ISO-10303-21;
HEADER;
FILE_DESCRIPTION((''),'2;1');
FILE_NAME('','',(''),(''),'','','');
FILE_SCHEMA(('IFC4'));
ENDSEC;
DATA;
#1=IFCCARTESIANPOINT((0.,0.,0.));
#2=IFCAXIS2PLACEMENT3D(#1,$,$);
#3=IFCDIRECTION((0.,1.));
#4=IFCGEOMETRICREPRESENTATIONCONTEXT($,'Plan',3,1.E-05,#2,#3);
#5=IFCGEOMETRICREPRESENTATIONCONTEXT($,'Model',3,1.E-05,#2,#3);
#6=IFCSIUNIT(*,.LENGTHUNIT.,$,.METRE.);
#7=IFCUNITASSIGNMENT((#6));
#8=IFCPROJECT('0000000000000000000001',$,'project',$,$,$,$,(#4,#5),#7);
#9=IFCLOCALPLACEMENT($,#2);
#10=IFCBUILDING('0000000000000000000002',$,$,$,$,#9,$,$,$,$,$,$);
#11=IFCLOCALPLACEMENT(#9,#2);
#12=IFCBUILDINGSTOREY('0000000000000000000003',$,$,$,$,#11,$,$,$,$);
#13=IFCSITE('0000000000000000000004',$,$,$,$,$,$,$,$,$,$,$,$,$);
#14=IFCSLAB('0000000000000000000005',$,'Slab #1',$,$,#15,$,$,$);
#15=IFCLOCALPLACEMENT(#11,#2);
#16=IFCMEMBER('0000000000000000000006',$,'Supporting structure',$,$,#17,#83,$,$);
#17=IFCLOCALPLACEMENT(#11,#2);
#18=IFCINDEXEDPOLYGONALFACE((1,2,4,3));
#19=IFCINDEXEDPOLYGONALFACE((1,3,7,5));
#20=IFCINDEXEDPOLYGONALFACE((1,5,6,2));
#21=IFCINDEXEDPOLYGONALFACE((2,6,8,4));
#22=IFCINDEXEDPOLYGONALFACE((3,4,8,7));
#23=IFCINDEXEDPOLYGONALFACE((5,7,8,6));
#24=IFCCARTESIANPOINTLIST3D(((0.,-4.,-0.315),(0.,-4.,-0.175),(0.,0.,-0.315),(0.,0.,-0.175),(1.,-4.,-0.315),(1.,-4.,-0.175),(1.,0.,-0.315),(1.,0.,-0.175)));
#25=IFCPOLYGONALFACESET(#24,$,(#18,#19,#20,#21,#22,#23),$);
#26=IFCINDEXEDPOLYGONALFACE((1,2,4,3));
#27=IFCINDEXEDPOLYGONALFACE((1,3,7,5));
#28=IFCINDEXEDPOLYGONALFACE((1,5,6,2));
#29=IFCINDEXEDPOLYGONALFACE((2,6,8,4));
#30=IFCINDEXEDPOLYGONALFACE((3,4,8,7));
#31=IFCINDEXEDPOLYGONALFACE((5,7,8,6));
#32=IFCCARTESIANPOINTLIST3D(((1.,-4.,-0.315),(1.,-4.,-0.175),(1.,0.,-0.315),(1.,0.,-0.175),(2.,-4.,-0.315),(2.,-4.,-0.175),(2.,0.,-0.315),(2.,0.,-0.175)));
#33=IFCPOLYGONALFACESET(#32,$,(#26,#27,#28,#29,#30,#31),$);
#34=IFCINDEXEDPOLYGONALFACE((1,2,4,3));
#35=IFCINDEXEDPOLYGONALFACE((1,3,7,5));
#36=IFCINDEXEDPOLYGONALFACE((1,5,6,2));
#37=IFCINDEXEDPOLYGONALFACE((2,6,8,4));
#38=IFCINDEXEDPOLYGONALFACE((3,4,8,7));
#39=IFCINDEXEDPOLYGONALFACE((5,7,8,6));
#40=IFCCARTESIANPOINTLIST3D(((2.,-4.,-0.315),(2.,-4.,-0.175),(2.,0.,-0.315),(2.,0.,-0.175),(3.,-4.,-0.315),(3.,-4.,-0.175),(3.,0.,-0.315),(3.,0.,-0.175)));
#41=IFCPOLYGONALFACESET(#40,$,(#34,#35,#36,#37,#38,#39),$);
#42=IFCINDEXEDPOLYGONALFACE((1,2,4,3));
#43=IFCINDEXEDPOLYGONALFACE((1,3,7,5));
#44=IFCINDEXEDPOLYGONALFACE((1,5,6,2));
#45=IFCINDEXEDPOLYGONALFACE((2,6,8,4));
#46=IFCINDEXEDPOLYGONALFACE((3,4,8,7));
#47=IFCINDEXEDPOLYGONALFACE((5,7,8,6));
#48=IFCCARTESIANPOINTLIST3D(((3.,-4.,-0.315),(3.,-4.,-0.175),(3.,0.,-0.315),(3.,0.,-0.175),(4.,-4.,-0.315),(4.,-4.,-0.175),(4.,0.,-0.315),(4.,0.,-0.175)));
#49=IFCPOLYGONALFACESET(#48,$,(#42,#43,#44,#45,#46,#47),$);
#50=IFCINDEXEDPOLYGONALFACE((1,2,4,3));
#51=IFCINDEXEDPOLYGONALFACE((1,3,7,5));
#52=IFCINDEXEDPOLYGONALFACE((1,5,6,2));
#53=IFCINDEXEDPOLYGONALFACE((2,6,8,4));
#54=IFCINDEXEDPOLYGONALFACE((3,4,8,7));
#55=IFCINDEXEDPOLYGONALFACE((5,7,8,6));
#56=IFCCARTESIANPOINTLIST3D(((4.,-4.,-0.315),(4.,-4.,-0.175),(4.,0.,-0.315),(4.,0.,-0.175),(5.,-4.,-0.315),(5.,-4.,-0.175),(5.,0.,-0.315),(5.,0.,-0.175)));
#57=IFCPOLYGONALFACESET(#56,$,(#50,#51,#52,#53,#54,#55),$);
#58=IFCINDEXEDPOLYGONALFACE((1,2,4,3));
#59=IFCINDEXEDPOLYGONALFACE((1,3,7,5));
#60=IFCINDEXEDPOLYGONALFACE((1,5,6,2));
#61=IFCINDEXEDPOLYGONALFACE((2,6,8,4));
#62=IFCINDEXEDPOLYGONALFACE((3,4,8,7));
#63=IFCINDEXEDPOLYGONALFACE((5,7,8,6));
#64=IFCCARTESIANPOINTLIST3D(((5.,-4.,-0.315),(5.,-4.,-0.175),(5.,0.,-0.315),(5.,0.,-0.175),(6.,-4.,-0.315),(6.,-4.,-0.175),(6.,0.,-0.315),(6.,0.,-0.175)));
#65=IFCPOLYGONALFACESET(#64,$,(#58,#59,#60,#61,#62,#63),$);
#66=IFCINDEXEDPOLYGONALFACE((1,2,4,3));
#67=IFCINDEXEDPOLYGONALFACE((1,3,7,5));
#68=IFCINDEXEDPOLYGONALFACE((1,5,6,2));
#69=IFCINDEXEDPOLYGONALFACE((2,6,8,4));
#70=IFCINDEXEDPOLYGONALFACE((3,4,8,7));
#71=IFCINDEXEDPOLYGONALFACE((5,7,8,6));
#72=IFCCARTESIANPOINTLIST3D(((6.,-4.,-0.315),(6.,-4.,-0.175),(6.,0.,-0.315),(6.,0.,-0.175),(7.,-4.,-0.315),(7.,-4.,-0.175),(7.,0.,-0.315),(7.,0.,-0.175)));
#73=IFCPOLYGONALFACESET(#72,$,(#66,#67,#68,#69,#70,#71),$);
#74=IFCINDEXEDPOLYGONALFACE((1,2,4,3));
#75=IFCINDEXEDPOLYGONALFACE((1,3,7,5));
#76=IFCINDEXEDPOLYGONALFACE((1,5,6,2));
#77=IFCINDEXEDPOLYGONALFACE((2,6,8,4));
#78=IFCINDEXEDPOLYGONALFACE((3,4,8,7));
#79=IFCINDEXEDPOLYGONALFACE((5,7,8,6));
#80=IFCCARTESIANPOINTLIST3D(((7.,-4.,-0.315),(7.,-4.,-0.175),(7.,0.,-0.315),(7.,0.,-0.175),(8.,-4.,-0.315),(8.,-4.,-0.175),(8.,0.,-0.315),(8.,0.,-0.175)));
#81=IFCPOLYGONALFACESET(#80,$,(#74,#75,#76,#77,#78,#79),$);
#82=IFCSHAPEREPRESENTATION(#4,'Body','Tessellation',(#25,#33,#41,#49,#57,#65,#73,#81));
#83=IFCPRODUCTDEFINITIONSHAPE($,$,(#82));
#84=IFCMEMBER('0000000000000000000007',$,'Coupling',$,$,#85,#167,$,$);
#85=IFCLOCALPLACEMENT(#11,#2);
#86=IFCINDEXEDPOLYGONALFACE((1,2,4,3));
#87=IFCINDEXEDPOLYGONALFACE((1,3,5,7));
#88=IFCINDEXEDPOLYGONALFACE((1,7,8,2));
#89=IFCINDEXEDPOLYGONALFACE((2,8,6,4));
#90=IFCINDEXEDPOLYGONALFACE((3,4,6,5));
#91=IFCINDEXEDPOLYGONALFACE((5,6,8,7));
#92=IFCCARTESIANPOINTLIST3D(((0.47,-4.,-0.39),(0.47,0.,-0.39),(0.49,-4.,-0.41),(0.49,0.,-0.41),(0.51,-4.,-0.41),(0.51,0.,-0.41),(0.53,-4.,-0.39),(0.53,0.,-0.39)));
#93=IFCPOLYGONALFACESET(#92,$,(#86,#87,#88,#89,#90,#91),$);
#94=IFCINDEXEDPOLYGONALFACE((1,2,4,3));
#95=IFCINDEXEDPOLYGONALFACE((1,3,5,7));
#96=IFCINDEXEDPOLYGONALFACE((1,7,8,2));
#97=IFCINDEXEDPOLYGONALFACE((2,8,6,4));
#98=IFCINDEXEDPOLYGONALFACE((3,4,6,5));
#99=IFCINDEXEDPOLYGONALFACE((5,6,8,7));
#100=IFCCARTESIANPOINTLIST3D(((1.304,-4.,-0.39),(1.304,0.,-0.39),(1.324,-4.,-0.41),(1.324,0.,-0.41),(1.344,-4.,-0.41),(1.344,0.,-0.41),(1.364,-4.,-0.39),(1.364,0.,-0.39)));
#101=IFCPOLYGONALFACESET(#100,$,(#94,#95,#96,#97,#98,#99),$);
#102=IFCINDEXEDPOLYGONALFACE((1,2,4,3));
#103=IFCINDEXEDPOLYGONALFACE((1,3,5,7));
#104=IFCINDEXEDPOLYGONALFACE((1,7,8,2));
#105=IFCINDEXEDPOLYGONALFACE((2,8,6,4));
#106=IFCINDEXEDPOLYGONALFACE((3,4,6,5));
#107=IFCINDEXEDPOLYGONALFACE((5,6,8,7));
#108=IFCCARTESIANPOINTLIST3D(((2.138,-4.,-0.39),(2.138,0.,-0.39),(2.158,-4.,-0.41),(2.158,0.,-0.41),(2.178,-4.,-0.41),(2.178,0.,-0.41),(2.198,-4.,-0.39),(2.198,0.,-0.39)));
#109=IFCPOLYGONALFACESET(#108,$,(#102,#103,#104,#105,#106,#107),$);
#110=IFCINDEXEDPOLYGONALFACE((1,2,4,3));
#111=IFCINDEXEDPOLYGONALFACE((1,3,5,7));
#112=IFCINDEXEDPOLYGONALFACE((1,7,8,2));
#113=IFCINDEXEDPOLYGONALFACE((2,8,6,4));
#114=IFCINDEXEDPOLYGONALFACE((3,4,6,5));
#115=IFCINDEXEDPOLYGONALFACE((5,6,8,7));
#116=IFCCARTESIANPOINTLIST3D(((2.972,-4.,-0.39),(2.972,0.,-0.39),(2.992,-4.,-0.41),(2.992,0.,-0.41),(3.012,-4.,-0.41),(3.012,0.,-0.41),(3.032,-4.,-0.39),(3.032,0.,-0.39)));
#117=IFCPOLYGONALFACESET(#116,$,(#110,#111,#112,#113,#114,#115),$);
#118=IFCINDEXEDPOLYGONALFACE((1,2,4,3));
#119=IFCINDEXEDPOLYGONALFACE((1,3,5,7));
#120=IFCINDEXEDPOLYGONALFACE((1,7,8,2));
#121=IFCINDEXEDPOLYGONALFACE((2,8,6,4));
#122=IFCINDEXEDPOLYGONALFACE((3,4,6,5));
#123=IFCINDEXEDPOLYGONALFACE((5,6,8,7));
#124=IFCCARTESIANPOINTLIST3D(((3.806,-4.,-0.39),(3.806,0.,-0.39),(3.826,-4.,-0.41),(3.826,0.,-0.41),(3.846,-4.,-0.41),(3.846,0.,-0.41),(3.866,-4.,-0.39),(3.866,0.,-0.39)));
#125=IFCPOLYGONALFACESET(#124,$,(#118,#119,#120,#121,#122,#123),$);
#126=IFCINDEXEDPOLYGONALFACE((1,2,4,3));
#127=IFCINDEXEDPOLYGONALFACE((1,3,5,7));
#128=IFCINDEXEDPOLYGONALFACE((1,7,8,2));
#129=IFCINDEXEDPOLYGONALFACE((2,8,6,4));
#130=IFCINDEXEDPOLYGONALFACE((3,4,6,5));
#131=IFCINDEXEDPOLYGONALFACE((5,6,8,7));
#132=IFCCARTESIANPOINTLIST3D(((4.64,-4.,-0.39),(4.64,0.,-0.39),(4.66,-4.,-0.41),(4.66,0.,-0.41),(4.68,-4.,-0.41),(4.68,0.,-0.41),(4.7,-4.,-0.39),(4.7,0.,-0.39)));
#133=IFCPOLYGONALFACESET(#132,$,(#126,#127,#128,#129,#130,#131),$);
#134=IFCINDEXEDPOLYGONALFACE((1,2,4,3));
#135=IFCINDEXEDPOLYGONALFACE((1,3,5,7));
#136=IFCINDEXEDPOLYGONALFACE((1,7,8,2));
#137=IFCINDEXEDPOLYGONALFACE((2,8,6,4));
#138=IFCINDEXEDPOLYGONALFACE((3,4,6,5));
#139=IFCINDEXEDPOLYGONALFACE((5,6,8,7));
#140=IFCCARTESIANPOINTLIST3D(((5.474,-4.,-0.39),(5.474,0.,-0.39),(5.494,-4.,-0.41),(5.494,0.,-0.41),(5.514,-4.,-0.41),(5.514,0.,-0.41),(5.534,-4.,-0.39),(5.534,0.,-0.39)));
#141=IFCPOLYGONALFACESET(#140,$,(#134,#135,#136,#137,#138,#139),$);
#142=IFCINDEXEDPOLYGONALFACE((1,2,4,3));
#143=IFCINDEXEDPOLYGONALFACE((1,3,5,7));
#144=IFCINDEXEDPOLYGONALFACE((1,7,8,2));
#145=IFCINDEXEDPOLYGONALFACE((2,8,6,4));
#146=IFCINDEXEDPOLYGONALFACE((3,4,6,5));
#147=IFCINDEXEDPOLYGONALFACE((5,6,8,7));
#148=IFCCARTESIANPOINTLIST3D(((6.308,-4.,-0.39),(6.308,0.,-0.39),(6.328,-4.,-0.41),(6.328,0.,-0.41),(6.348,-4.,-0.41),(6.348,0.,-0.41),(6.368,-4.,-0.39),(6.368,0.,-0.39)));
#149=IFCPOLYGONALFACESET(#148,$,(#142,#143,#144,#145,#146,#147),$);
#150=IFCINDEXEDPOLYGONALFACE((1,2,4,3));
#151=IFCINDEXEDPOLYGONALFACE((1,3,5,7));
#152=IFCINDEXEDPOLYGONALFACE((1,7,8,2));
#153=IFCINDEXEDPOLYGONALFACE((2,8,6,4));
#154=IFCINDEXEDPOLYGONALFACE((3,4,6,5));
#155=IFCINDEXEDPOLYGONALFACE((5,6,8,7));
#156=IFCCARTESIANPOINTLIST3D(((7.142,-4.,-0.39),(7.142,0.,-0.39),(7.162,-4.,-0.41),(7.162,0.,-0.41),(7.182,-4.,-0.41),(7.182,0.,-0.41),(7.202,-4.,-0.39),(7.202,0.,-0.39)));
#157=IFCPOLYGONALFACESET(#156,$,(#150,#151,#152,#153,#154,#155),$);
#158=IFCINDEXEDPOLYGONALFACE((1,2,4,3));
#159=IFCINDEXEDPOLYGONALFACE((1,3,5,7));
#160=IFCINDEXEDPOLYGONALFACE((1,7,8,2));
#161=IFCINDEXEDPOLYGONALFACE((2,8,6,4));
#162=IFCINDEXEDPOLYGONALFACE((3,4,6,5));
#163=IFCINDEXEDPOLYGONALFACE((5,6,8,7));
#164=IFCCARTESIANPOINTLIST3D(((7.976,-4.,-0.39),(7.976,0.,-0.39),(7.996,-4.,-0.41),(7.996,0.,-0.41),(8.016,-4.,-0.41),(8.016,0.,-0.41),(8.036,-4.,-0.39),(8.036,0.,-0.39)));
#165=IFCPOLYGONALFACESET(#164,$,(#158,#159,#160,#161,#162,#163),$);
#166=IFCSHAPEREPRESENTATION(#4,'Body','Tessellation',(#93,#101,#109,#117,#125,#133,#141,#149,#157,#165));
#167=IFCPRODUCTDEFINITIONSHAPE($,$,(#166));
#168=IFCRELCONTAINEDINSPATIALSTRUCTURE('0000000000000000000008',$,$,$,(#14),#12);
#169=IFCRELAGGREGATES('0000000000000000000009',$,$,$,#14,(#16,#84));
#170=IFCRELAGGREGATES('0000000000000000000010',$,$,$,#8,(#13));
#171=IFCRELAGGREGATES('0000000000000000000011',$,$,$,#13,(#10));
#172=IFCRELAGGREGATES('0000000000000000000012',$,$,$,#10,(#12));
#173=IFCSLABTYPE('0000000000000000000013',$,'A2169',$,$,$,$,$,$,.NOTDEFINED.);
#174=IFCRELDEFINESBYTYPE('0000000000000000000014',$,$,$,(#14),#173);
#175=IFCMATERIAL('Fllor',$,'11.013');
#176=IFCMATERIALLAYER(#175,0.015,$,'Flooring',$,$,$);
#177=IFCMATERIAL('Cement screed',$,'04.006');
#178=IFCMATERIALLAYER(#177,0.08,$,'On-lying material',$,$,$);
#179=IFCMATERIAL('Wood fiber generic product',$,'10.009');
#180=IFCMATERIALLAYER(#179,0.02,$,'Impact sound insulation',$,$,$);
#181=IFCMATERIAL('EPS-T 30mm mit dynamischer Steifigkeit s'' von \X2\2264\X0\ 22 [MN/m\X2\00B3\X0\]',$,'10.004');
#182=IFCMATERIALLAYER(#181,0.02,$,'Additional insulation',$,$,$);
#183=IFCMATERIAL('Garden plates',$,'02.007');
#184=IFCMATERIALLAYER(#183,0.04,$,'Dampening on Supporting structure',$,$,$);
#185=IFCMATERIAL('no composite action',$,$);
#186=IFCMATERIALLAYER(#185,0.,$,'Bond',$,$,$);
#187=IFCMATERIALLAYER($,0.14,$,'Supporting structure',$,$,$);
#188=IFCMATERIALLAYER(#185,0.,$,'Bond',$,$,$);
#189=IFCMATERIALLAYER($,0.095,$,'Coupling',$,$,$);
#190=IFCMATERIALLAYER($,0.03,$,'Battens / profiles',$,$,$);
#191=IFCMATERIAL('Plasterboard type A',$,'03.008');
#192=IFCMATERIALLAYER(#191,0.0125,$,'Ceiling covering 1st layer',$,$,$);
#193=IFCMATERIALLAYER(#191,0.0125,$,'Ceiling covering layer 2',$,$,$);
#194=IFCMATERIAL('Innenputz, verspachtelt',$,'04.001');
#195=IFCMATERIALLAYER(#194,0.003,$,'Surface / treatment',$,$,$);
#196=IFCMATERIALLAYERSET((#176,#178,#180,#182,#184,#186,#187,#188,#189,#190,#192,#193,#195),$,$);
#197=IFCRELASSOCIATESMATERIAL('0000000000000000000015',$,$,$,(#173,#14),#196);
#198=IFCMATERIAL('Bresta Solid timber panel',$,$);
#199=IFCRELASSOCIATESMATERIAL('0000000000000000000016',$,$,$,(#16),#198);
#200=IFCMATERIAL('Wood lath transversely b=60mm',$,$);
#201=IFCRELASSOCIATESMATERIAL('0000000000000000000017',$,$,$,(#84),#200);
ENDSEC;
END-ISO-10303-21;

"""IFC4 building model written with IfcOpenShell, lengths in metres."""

from ifc_helpers import new_model, si_unit, direction, frame, frame_2d, origin, place, context, project, spatial, polyline, rectangle, outline, extrude, material, layer, layer_set, type_object, element, aggregate, save


model = new_model("IFC4")

# Units and contexts
plan_context = context("Plan", 3, precision=1e-05, world=origin(), true_north=direction((0.0, 1.0)))
model_context = context("Model", 3, precision=1e-05, world=origin(), true_north=direction((0.0, 1.0)))
ifc_project = project(units=[si_unit("LENGTHUNIT", "METRE")], contexts=[plan_context, model_context])

# Site, building, storey
site = spatial("IfcSite", under=ifc_project)
building_placement = place(None, origin())
building = spatial("IfcBuilding", under=site, at=building_placement)
storey_placement = place(building_placement, origin())
storey = spatial("IfcBuildingStorey", under=building, at=storey_placement)

# Slab, members
ifc_material_1 = material(Name="Fllor", Category="11.013")
ifc_layer_1 = layer(ifc_material_1, 0.015, Name="Flooring")
ifc_material_2 = material(Name="Cement screed", Category="04.006")
ifc_layer_2 = layer(ifc_material_2, 0.08, Name="On-lying material")
ifc_material_3 = material(Name="Wood fiber generic product", Category="10.009")
ifc_layer_3 = layer(ifc_material_3, 0.02, Name="Impact sound insulation")
ifc_material_4 = material(Name="EPS-T 30mm mit dynamischer Steifigkeit s' von ≤ 22 [MN/m³]", Category="10.004")
ifc_layer_4 = layer(ifc_material_4, 0.02, Name="Additional insulation")
ifc_material_5 = material(Name="Garden plates", Category="02.007")
ifc_layer_5 = layer(ifc_material_5, 0.04, Name="Dampening on Supporting structure")
ifc_material_6 = material(Name="no composite action")
ifc_layer_6 = layer(ifc_material_6, 0.0, Name="Bond")
ifc_layer_7 = layer(None, 0.14, Name="Supporting structure")
ifc_layer_8 = layer(ifc_material_6, 0.0, Name="Bond")
ifc_layer_9 = layer(None, 0.095, Name="Coupling")
ifc_layer_10 = layer(None, 0.03, Name="Battens / profiles")
ifc_material_7 = material(Name="Plasterboard type A", Category="03.008")
ifc_layer_11 = layer(ifc_material_7, 0.0125, Name="Ceiling covering 1st layer")
ifc_layer_12 = layer(ifc_material_7, 0.0125, Name="Ceiling covering layer 2")
ifc_material_8 = material(Name="Innenputz, verspachtelt", Category="04.001")
ifc_layer_13 = layer(ifc_material_8, 0.003, Name="Surface / treatment")
ifc_layer_set = layer_set([ifc_layer_1, ifc_layer_2, ifc_layer_3, ifc_layer_4, ifc_layer_5, ifc_layer_6, ifc_layer_7, ifc_layer_8, ifc_layer_9, ifc_layer_10, ifc_layer_11, ifc_layer_12, ifc_layer_13])
slab_type = type_object("IfcSlabType", Name="A2169", PredefinedType="NOTDEFINED", material=ifc_layer_set)
slab_placement = place(None, frame((0.0, 0.0, 0.0), z_axis=(0.0, 0.0, -1.0), x_axis=(1.0, 0.0, 0.0)))
slab = element("IfcSlab", 1, at=slab_placement, inside=storey, type_object=slab_type, material=ifc_layer_set, Name="Slab #1")
ifc_material_9 = material(Name="Bresta Solid timber panel")
member_1_placement = place(slab_placement, origin())
member_1 = element("IfcMember", 2, at=member_1_placement, material=ifc_material_9, Name="Supporting structure", context=plan_context, shape_type="SweptSolid", body=[
    extrude(rectangle(XDim=1.0, YDim=0.14, at=frame_2d((0.5, 0.07), x_axis=(1.0, 0.0))), frame((0.0, 4.0, 0.175), z_axis=(0.0, -1.0, 0.0), x_axis=(1.0, 0.0, 0.0)), (0.0, 0.0, 1.0), 4.0),
    extrude(rectangle(XDim=1.0, YDim=0.14, at=frame_2d((0.5, 0.07), x_axis=(1.0, 0.0))), frame((1.0, 4.0, 0.175), z_axis=(0.0, -1.0, 0.0), x_axis=(1.0, 0.0, 0.0)), (0.0, 0.0, 1.0), 4.0),
    extrude(rectangle(XDim=1.0, YDim=0.14, at=frame_2d((0.5, 0.07), x_axis=(1.0, 0.0))), frame((2.0, 4.0, 0.175), z_axis=(0.0, -1.0, 0.0), x_axis=(1.0, 0.0, 0.0)), (0.0, 0.0, 1.0), 4.0),
    extrude(rectangle(XDim=1.0, YDim=0.14, at=frame_2d((0.5, 0.07), x_axis=(1.0, 0.0))), frame((3.0, 4.0, 0.175), z_axis=(0.0, -1.0, 0.0), x_axis=(1.0, 0.0, 0.0)), (0.0, 0.0, 1.0), 4.0),
    extrude(rectangle(XDim=1.0, YDim=0.14, at=frame_2d((0.5, 0.07), x_axis=(1.0, 0.0))), frame((4.0, 4.0, 0.175), z_axis=(0.0, -1.0, 0.0), x_axis=(1.0, 0.0, 0.0)), (0.0, 0.0, 1.0), 4.0),
    extrude(rectangle(XDim=1.0, YDim=0.14, at=frame_2d((0.5, 0.07), x_axis=(1.0, 0.0))), frame((5.0, 4.0, 0.175), z_axis=(0.0, -1.0, 0.0), x_axis=(1.0, 0.0, 0.0)), (0.0, 0.0, 1.0), 4.0),
    extrude(rectangle(XDim=1.0, YDim=0.14, at=frame_2d((0.5, 0.07), x_axis=(1.0, 0.0))), frame((6.0, 4.0, 0.175), z_axis=(0.0, -1.0, 0.0), x_axis=(1.0, 0.0, 0.0)), (0.0, 0.0, 1.0), 4.0),
    extrude(rectangle(XDim=1.0, YDim=0.14, at=frame_2d((0.5, 0.07), x_axis=(1.0, 0.0))), frame((7.0, 4.0, 0.175), z_axis=(0.0, -1.0, 0.0), x_axis=(1.0, 0.0, 0.0)), (0.0, 0.0, 1.0), 4.0),
])
ifc_material_10 = material(Name="Wood lath transversely b=60mm")
member_2_placement = place(slab_placement, origin())
member_2 = element("IfcMember", 3, at=member_2_placement, material=ifc_material_10, Name="Coupling", context=plan_context, shape_type="SweptSolid", body=[
    extrude(outline(polyline([(0.0, 0.0), (0.06, 0.0), (0.04, 0.02), (0.02, 0.02), (0.0, 0.0)])), frame((0.47, 4.0, 0.39), z_axis=(0.0, -1.0, 0.0), x_axis=(1.0, 0.0, 0.0)), (0.0, 0.0, 1.0), 4.0),
    extrude(outline(polyline([(0.0, 0.0), (0.06, 0.0), (0.04, 0.02), (0.02, 0.02), (0.0, 0.0)])), frame((1.304, 4.0, 0.39), z_axis=(0.0, -1.0, 0.0), x_axis=(1.0, 0.0, 0.0)), (0.0, 0.0, 1.0), 4.0),
    extrude(outline(polyline([(0.0, 0.0), (0.06, 0.0), (0.04, 0.02), (0.02, 0.02), (0.0, 0.0)])), frame((2.138, 4.0, 0.39), z_axis=(0.0, -1.0, 0.0), x_axis=(1.0, 0.0, 0.0)), (0.0, 0.0, 1.0), 4.0),
    extrude(outline(polyline([(0.0, 0.0), (0.06, 0.0), (0.04, 0.02), (0.02, 0.02), (0.0, 0.0)])), frame((2.972, 4.0, 0.39), z_axis=(0.0, -1.0, 0.0), x_axis=(1.0, 0.0, 0.0)), (0.0, 0.0, 1.0), 4.0),
    extrude(outline(polyline([(0.0, 0.0), (0.06, 0.0), (0.04, 0.02), (0.02, 0.02), (0.0, 0.0)])), frame((3.806, 4.0, 0.39), z_axis=(0.0, -1.0, 0.0), x_axis=(1.0, 0.0, 0.0)), (0.0, 0.0, 1.0), 4.0),
    extrude(outline(polyline([(0.0, 0.0), (0.06, 0.0), (0.04, 0.02), (0.02, 0.02), (0.0, 0.0)])), frame((4.64, 4.0, 0.39), z_axis=(0.0, -1.0, 0.0), x_axis=(1.0, 0.0, 0.0)), (0.0, 0.0, 1.0), 4.0),
    extrude(outline(polyline([(0.0, 0.0), (0.06, 0.0), (0.04, 0.02), (0.02, 0.02), (0.0, 0.0)])), frame((5.474, 4.0, 0.39), z_axis=(0.0, -1.0, 0.0), x_axis=(1.0, 0.0, 0.0)), (0.0, 0.0, 1.0), 4.0),
    extrude(outline(polyline([(0.0, 0.0), (0.06, 0.0), (0.04, 0.02), (0.02, 0.02), (0.0, 0.0)])), frame((6.308, 4.0, 0.39), z_axis=(0.0, -1.0, 0.0), x_axis=(1.0, 0.0, 0.0)), (0.0, 0.0, 1.0), 4.0),
    extrude(outline(polyline([(0.0, 0.0), (0.06, 0.0), (0.04, 0.02), (0.02, 0.02), (0.0, 0.0)])), frame((7.142, 4.0, 0.39), z_axis=(0.0, -1.0, 0.0), x_axis=(1.0, 0.0, 0.0)), (0.0, 0.0, 1.0), 4.0),
    extrude(outline(polyline([(0.0, 0.0), (0.06, 0.0), (0.04, 0.02), (0.02, 0.02), (0.0, 0.0)])), frame((7.976, 4.0, 0.39), z_axis=(0.0, -1.0, 0.0), x_axis=(1.0, 0.0, 0.0)), (0.0, 0.0, 1.0), 4.0),
])
aggregate(slab, [member_1, member_2])

save(model, "model.ifc")
